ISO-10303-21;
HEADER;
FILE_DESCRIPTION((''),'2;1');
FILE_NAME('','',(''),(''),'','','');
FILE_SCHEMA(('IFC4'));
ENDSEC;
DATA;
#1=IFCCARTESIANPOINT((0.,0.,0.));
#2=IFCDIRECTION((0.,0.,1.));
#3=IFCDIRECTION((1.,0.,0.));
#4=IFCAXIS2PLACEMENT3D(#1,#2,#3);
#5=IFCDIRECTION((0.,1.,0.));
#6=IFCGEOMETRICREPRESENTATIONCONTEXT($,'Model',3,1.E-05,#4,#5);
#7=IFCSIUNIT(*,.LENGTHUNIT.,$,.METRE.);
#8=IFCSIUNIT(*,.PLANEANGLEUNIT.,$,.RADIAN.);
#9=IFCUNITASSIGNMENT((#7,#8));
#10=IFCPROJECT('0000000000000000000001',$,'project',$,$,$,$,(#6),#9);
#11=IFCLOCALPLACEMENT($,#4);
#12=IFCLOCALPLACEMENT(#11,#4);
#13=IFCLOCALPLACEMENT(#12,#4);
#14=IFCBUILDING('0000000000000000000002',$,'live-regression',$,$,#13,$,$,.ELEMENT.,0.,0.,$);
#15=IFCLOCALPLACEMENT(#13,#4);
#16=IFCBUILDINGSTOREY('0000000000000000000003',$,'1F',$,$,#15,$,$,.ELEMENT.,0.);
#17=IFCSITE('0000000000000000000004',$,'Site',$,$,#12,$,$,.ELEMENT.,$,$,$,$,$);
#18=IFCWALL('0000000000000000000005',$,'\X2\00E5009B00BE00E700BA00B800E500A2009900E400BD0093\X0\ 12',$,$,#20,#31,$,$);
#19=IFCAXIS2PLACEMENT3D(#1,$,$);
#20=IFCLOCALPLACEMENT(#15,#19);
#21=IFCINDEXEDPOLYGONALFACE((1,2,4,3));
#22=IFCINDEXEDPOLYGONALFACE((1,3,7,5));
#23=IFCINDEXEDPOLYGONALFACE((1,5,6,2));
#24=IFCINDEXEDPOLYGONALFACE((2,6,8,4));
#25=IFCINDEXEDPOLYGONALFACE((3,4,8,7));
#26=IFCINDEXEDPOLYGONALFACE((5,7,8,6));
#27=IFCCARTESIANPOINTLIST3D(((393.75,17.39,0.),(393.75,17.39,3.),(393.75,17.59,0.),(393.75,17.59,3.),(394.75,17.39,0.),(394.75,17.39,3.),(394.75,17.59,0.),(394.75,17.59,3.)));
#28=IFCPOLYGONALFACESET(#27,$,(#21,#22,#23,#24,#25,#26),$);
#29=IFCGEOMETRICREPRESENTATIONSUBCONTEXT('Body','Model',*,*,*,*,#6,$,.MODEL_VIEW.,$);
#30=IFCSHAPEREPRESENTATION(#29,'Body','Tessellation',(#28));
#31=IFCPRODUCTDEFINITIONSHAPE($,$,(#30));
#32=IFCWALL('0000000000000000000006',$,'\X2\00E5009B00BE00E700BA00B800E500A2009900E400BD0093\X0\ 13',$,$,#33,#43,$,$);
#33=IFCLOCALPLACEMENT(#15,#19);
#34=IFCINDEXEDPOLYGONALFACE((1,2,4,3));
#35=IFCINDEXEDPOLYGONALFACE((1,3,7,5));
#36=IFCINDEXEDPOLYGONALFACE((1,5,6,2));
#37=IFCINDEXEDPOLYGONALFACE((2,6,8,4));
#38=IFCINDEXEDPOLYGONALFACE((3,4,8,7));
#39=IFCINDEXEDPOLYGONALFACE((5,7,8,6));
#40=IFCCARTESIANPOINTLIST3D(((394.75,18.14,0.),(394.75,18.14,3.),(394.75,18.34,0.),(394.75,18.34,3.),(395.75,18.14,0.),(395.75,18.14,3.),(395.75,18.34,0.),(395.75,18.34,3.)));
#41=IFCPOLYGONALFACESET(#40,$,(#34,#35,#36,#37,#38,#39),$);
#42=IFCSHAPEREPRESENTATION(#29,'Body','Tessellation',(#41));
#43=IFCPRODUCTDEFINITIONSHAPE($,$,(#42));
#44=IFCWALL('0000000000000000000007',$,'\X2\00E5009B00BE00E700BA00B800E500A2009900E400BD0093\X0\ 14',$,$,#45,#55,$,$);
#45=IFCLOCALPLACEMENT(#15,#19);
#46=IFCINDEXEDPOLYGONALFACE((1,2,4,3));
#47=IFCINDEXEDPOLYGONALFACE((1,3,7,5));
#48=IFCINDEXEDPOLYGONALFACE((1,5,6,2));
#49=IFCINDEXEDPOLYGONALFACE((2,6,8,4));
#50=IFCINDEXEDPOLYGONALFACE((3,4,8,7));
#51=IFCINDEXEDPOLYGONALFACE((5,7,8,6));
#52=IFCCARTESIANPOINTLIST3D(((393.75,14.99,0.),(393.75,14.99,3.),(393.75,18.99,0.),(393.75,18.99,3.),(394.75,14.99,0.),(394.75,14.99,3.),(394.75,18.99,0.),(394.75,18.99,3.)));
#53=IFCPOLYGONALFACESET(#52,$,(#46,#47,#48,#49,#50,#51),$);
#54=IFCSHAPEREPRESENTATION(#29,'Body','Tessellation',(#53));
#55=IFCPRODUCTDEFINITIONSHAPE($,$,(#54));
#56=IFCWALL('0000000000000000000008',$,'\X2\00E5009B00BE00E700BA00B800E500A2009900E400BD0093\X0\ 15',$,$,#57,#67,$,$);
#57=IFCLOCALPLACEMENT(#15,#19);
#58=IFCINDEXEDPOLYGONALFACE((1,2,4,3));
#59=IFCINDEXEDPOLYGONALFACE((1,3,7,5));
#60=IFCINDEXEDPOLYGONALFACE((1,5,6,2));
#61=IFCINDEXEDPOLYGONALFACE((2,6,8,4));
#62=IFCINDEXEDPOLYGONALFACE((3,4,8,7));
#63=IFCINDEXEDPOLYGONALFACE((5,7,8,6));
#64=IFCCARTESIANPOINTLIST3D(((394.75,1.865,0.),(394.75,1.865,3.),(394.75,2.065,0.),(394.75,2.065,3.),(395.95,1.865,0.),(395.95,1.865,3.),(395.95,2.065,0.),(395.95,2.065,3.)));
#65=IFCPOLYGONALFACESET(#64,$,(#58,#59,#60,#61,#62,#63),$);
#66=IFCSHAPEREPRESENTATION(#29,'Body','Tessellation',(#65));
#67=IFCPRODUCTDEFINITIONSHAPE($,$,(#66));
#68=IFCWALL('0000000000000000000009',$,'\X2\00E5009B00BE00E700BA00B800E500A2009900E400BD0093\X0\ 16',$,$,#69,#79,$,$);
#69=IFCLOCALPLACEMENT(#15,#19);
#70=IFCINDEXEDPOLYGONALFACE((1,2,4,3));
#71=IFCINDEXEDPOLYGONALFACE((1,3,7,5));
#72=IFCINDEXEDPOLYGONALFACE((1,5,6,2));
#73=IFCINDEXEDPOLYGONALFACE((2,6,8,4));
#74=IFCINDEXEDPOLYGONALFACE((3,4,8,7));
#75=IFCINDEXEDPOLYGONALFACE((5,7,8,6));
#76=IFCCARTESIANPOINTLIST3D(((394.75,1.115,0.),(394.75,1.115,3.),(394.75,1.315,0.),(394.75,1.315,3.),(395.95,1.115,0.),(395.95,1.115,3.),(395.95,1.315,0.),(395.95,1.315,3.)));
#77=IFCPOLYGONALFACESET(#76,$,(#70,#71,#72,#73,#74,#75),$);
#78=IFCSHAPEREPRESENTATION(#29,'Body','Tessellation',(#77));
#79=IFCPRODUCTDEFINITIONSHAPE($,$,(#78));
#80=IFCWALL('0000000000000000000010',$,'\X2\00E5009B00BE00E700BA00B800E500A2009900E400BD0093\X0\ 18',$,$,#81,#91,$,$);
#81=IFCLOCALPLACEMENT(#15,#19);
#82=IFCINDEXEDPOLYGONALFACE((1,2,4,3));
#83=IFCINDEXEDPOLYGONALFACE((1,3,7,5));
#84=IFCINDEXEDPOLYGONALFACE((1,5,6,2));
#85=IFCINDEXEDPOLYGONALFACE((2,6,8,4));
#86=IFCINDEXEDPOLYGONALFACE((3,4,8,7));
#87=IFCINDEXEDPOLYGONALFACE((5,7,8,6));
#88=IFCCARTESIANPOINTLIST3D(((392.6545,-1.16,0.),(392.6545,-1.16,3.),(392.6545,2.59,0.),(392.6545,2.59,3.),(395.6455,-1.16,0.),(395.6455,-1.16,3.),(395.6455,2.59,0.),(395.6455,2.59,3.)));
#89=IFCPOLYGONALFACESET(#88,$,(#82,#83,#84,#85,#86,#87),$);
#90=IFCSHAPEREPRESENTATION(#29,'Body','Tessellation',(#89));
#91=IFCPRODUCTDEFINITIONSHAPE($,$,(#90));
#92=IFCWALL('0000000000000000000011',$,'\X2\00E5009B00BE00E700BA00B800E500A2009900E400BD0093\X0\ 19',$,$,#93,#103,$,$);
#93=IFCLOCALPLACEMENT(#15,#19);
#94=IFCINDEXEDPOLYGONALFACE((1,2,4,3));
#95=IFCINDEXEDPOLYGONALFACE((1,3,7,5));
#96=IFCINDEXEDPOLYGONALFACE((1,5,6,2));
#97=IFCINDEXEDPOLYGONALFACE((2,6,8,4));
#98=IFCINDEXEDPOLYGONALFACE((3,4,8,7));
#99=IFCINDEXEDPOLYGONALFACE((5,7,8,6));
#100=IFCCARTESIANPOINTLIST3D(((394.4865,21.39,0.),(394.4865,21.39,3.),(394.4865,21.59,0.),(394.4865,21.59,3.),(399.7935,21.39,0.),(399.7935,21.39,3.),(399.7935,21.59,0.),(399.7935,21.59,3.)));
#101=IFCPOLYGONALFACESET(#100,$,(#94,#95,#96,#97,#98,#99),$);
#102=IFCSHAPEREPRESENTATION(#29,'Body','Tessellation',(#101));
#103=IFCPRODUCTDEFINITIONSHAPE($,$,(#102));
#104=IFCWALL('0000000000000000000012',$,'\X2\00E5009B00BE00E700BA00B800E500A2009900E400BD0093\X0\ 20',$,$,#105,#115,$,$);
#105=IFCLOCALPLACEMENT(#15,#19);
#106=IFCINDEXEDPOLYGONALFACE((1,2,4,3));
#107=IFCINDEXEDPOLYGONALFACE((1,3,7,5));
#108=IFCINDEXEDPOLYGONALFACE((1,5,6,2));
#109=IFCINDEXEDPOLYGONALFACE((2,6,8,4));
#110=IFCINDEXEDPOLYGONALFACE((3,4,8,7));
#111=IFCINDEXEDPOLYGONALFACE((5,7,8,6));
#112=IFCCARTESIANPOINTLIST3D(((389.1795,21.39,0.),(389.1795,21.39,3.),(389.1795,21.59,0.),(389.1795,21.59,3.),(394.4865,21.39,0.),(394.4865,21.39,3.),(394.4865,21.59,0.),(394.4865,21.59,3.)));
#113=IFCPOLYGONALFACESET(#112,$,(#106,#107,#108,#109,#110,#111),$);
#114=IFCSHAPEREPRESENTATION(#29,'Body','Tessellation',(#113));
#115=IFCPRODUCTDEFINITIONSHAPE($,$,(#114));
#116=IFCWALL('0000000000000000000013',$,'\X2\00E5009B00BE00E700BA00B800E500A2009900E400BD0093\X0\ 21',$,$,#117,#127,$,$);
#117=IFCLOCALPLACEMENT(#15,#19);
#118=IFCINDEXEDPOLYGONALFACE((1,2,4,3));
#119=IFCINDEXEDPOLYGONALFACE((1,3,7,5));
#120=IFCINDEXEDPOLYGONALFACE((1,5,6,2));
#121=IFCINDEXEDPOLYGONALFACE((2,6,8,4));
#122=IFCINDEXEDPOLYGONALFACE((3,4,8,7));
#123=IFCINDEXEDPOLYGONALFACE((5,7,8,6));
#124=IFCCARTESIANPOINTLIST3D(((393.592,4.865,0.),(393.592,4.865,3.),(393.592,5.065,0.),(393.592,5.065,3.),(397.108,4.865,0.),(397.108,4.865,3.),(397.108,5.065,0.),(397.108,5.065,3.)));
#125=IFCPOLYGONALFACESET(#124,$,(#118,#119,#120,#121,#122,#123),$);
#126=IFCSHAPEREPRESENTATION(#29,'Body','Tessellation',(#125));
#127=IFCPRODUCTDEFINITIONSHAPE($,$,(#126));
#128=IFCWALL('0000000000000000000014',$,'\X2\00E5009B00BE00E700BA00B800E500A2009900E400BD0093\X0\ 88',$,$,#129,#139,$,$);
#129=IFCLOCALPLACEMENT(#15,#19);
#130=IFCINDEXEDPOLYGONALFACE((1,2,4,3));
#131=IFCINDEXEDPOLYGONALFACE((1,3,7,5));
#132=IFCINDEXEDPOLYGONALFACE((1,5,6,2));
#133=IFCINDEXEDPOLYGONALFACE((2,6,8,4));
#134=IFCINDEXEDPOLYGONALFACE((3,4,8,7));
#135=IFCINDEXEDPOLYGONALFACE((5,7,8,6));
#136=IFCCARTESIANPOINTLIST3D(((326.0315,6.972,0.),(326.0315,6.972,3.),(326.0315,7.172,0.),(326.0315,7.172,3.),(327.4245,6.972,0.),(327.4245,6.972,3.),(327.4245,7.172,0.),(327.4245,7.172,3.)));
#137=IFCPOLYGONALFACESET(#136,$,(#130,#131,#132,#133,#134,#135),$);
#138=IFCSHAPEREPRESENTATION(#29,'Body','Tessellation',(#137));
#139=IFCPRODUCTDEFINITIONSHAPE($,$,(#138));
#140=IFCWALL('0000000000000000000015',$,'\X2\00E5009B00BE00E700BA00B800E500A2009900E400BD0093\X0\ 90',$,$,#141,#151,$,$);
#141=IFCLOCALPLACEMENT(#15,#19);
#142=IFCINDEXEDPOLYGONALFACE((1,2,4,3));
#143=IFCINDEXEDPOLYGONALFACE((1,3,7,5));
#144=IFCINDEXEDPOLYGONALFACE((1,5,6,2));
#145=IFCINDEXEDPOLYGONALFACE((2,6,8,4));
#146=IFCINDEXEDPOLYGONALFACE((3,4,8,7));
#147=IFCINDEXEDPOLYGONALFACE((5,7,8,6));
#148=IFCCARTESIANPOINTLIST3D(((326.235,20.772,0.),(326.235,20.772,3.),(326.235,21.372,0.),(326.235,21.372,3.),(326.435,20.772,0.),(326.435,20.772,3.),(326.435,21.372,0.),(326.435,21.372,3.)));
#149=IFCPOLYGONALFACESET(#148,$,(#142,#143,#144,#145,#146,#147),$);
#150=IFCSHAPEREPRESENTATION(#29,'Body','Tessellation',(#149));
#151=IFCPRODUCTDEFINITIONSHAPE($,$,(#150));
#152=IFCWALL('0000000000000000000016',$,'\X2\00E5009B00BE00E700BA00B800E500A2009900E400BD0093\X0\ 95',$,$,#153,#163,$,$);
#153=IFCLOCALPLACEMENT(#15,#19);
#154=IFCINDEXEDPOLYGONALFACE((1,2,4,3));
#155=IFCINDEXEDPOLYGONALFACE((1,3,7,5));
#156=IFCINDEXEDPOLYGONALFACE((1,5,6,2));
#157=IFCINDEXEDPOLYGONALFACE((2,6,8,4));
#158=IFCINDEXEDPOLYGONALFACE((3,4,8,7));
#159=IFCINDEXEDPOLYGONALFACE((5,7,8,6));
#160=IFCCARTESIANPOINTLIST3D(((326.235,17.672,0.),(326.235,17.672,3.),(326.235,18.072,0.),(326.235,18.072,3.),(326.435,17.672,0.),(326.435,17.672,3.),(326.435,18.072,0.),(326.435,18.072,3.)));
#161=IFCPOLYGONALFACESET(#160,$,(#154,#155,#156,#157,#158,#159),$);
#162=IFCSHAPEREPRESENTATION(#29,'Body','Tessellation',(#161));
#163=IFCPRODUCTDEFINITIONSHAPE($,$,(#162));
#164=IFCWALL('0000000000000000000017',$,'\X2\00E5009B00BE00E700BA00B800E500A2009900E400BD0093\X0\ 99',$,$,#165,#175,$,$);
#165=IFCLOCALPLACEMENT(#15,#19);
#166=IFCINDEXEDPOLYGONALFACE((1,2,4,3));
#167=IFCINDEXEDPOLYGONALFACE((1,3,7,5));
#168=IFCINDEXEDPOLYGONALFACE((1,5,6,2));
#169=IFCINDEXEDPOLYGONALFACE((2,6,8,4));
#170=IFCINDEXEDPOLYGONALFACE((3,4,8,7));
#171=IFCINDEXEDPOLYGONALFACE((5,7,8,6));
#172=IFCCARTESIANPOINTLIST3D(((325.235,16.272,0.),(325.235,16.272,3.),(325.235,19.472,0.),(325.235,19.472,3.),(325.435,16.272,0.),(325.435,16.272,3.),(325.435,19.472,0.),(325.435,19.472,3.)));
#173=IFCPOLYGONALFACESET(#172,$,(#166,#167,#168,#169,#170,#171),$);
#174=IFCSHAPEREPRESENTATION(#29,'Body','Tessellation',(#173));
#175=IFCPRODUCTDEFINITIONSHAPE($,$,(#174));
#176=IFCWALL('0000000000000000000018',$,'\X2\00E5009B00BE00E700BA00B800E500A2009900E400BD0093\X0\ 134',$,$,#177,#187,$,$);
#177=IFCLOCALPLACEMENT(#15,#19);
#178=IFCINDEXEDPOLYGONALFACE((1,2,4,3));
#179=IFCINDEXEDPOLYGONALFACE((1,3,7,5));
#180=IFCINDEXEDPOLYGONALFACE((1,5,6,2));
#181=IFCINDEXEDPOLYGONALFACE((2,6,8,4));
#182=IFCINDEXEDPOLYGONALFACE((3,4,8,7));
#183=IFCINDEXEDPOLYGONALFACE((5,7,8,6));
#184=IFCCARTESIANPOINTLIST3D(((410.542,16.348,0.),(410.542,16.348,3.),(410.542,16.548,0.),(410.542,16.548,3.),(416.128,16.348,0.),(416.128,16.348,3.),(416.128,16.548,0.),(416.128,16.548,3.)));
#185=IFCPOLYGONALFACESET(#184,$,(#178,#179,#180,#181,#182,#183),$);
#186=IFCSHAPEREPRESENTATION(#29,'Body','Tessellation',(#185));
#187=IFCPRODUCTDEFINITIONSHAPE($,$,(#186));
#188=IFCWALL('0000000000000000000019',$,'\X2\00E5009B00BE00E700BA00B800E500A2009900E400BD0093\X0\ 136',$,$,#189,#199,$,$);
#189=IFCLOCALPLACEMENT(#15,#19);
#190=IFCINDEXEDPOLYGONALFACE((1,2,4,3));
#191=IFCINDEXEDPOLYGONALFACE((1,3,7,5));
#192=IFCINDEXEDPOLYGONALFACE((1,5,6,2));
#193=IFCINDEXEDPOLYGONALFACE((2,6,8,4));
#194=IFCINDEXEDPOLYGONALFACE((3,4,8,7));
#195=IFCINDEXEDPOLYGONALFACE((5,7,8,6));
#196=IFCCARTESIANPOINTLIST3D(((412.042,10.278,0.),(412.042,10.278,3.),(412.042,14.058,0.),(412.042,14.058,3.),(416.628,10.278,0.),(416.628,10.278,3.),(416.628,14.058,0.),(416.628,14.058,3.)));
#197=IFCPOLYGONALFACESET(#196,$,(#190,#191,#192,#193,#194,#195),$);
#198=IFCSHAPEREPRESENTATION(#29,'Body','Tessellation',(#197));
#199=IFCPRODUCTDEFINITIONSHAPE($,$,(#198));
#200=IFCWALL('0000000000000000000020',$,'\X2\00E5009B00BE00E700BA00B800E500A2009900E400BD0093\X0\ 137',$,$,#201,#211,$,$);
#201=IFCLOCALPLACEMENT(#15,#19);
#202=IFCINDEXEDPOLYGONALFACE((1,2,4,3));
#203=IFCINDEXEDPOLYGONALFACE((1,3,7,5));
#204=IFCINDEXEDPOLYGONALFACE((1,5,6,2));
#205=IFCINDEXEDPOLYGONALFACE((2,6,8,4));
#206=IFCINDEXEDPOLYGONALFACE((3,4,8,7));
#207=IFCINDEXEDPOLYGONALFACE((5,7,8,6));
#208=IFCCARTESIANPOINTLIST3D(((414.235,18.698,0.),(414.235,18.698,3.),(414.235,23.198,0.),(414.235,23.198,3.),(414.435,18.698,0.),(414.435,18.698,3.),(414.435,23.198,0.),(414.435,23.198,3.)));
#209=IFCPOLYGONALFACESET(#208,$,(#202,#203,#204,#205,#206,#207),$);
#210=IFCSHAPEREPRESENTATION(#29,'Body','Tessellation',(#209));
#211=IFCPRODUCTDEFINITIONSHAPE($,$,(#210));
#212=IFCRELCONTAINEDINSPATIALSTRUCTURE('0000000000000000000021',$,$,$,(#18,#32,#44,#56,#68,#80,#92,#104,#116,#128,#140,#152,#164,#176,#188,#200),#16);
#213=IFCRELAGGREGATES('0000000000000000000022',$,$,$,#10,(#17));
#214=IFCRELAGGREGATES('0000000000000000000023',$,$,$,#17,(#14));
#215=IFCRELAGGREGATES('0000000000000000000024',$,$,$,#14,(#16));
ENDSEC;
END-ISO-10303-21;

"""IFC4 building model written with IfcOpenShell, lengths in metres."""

from ifc_helpers import new_model, si_unit, direction, frame, frame_2d, origin_with_axes, place, context, subcontext, project, spatial, rectangle, extrude, element, save


model = new_model("IFC4")

# Units and contexts
model_context = context("Model", 3, precision=1e-05, world=origin_with_axes(), true_north=direction((0.0, 1.0, 0.0)))
body_context = subcontext(model_context, "Body", "Model", "MODEL_VIEW")
ifc_project = project(units=[si_unit("LENGTHUNIT", "METRE"), si_unit("PLANEANGLEUNIT", "RADIAN")], contexts=[model_context])

# Site, building, storey
placement = place(None, origin_with_axes())
site_placement = place(placement, origin_with_axes())
site = spatial("IfcSite", under=ifc_project, at=site_placement, Name="Site", CompositionType="ELEMENT")
building_placement = place(site_placement, origin_with_axes())
building = spatial("IfcBuilding", under=site, at=building_placement, Name="live-regression", CompositionType="ELEMENT", ElevationOfRefHeight=0.0, ElevationOfTerrain=0.0)
storey_placement = place(building_placement, origin_with_axes())
storey = spatial("IfcBuildingStorey", under=building, at=storey_placement, Name="1F", CompositionType="ELEMENT", Elevation=0.0)

# Walls
for number, where, z_axis, x_axis, name in (
    (1, (394.25, 17.49, 0.0), (0.0, 0.0, 1.0), (1.0, 0.0, 0.0), "å\u009b¾çº¸å¢\u0099ä½\u0093 12"),
    (2, (395.25, 18.24, 0.0), (0.0, 0.0, 1.0), (-1.0, 0.0, 0.0), "å\u009b¾çº¸å¢\u0099ä½\u0093 13"),
):
    element("IfcWall", number, at=place(storey_placement, frame(where, z_axis=z_axis, x_axis=x_axis)), inside=storey, Name=name, context=body_context, shape_type="SweptSolid", body=[
        extrude(rectangle(XDim=1.0, YDim=0.2, at=frame_2d((0.0, 0.0), x_axis=(1.0, 0.0, 0.0))), frame((0.0, 0.0, 0.0), z_axis=(0.0, 0.0, 1.0)), (0.0, 0.0, 1.0), 3.0),
    ])
wall_1_placement = place(storey_placement, frame((394.25, 16.99, 0.0), z_axis=(0.0, 0.0, 1.0), x_axis=(1.0, 0.0, 0.0)))
element("IfcWall", 3, at=wall_1_placement, inside=storey, Name="å\u009b¾çº¸å¢\u0099ä½\u0093 14", context=body_context, shape_type="SweptSolid", body=[
    extrude(rectangle(XDim=1.0, YDim=4.0, at=frame_2d((0.0, 0.0), x_axis=(1.0, 0.0, 0.0))), frame((0.0, 0.0, 0.0), z_axis=(0.0, 0.0, 1.0)), (0.0, 0.0, 1.0), 3.0),
])
for number, where, z_axis, x_axis, name in (
    (4, (395.35, 1.965, 0.0), (0.0, 0.0, 1.0), (-1.0, 0.0, 0.0), "å\u009b¾çº¸å¢\u0099ä½\u0093 15"),
    (5, (395.35, 1.215, 0.0), (0.0, 0.0, 1.0), (-1.0, 0.0, 0.0), "å\u009b¾çº¸å¢\u0099ä½\u0093 16"),
):
    element("IfcWall", number, at=place(storey_placement, frame(where, z_axis=z_axis, x_axis=x_axis)), inside=storey, Name=name, context=body_context, shape_type="SweptSolid", body=[
        extrude(rectangle(XDim=1.2, YDim=0.2, at=frame_2d((0.0, 0.0), x_axis=(1.0, 0.0, 0.0))), frame((0.0, 0.0, 0.0), z_axis=(0.0, 0.0, 1.0)), (0.0, 0.0, 1.0), 3.0),
    ])
wall_2_placement = place(storey_placement, frame((394.15, 0.715, 0.0), z_axis=(0.0, 0.0, 1.0), x_axis=(1.0, 0.0, 0.0)))
element("IfcWall", 6, at=wall_2_placement, inside=storey, Name="å\u009b¾çº¸å¢\u0099ä½\u0093 18", context=body_context, shape_type="SweptSolid", body=[
    extrude(rectangle(XDim=2.991, YDim=3.75, at=frame_2d((0.0, 0.0), x_axis=(1.0, 0.0, 0.0))), frame((0.0, 0.0, 0.0), z_axis=(0.0, 0.0, 1.0)), (0.0, 0.0, 1.0), 3.0),
])
for number, where, z_axis, x_axis, name in (
    (7, (397.14, 21.49, 0.0), (0.0, 0.0, 1.0), (-1.0, 0.0, 0.0), "å\u009b¾çº¸å¢\u0099ä½\u0093 19"),
    (8, (391.833, 21.49, 0.0), (0.0, 0.0, 1.0), (1.0, 0.0, 0.0), "å\u009b¾çº¸å¢\u0099ä½\u0093 20"),
):
    element("IfcWall", number, at=place(storey_placement, frame(where, z_axis=z_axis, x_axis=x_axis)), inside=storey, Name=name, context=body_context, shape_type="SweptSolid", body=[
        extrude(rectangle(XDim=5.307, YDim=0.2, at=frame_2d((0.0, 0.0), x_axis=(1.0, 0.0, 0.0))), frame((0.0, 0.0, 0.0), z_axis=(0.0, 0.0, 1.0)), (0.0, 0.0, 1.0), 3.0),
    ])
wall_3_placement = place(storey_placement, frame((395.35, 4.965, 0.0), z_axis=(0.0, 0.0, 1.0), x_axis=(-1.0, 0.0, 0.0)))
element("IfcWall", 9, at=wall_3_placement, inside=storey, Name="å\u009b¾çº¸å¢\u0099ä½\u0093 21", context=body_context, shape_type="SweptSolid", body=[
    extrude(rectangle(XDim=3.516, YDim=0.2, at=frame_2d((0.0, 0.0), x_axis=(1.0, 0.0, 0.0))), frame((0.0, 0.0, 0.0), z_axis=(0.0, 0.0, 1.0)), (0.0, 0.0, 1.0), 3.0),
])
wall_4_placement = place(storey_placement, frame((326.728, 7.072, 0.0), z_axis=(0.0, 0.0, 1.0), x_axis=(-1.0, 0.0, 0.0)))
element("IfcWall", 10, at=wall_4_placement, inside=storey, Name="å\u009b¾çº¸å¢\u0099ä½\u0093 88", context=body_context, shape_type="SweptSolid", body=[
    extrude(rectangle(XDim=1.393, YDim=0.2, at=frame_2d((0.0, 0.0), x_axis=(1.0, 0.0, 0.0))), frame((0.0, 0.0, 0.0), z_axis=(0.0, 0.0, 1.0)), (0.0, 0.0, 1.0), 3.0),
])
wall_5_placement = place(storey_placement, frame((326.335, 21.072, 0.0), z_axis=(0.0, 0.0, 1.0), x_axis=(0.0, 1.0, 0.0)))
element("IfcWall", 11, at=wall_5_placement, inside=storey, Name="å\u009b¾çº¸å¢\u0099ä½\u0093 90", context=body_context, shape_type="SweptSolid", body=[
    extrude(rectangle(XDim=0.6, YDim=0.2, at=frame_2d((0.0, 0.0), x_axis=(1.0, 0.0, 0.0))), frame((0.0, 0.0, 0.0), z_axis=(0.0, 0.0, 1.0)), (0.0, 0.0, 1.0), 3.0),
])
wall_6_placement = place(storey_placement, frame((326.335, 17.872, 0.0), z_axis=(0.0, 0.0, 1.0), x_axis=(0.0, -1.0, 0.0)))
element("IfcWall", 12, at=wall_6_placement, inside=storey, Name="å\u009b¾çº¸å¢\u0099ä½\u0093 95", context=body_context, shape_type="SweptSolid", body=[
    extrude(rectangle(XDim=0.4, YDim=0.2, at=frame_2d((0.0, 0.0), x_axis=(1.0, 0.0, 0.0))), frame((0.0, 0.0, 0.0), z_axis=(0.0, 0.0, 1.0)), (0.0, 0.0, 1.0), 3.0),
])
wall_7_placement = place(storey_placement, frame((325.335, 17.872, 0.0), z_axis=(0.0, 0.0, 1.0), x_axis=(0.0, 1.0, 0.0)))
element("IfcWall", 13, at=wall_7_placement, inside=storey, Name="å\u009b¾çº¸å¢\u0099ä½\u0093 99", context=body_context, shape_type="SweptSolid", body=[
    extrude(rectangle(XDim=3.2, YDim=0.2, at=frame_2d((0.0, 0.0), x_axis=(1.0, 0.0, 0.0))), frame((0.0, 0.0, 0.0), z_axis=(0.0, 0.0, 1.0)), (0.0, 0.0, 1.0), 3.0),
])
wall_8_placement = place(storey_placement, frame((413.335, 16.448, 0.0), z_axis=(0.0, 0.0, 1.0), x_axis=(1.0, 0.0, 0.0)))
element("IfcWall", 14, at=wall_8_placement, inside=storey, Name="å\u009b¾çº¸å¢\u0099ä½\u0093 134", context=body_context, shape_type="SweptSolid", body=[
    extrude(rectangle(XDim=5.586, YDim=0.2, at=frame_2d((0.0, 0.0), x_axis=(1.0, 0.0, 0.0))), frame((0.0, 0.0, 0.0), z_axis=(0.0, 0.0, 1.0)), (0.0, 0.0, 1.0), 3.0),
])
wall_9_placement = place(storey_placement, frame((414.335, 12.168, 0.0), z_axis=(0.0, 0.0, 1.0), x_axis=(1.0, 0.0, 0.0)))
element("IfcWall", 15, at=wall_9_placement, inside=storey, Name="å\u009b¾çº¸å¢\u0099ä½\u0093 136", context=body_context, shape_type="SweptSolid", body=[
    extrude(rectangle(XDim=4.586, YDim=3.78, at=frame_2d((0.0, 0.0), x_axis=(1.0, 0.0, 0.0))), frame((0.0, 0.0, 0.0), z_axis=(0.0, 0.0, 1.0)), (0.0, 0.0, 1.0), 3.0),
])
wall_10_placement = place(storey_placement, frame((414.335, 20.948, 0.0), z_axis=(0.0, 0.0, 1.0), x_axis=(0.0, -1.0, 0.0)))
element("IfcWall", 16, at=wall_10_placement, inside=storey, Name="å\u009b¾çº¸å¢\u0099ä½\u0093 137", context=body_context, shape_type="SweptSolid", body=[
    extrude(rectangle(XDim=4.5, YDim=0.2, at=frame_2d((0.0, 0.0), x_axis=(1.0, 0.0, 0.0))), frame((0.0, 0.0, 0.0), z_axis=(0.0, 0.0, 1.0)), (0.0, 0.0, 1.0), 3.0),
])

save(model, "model.ifc")
